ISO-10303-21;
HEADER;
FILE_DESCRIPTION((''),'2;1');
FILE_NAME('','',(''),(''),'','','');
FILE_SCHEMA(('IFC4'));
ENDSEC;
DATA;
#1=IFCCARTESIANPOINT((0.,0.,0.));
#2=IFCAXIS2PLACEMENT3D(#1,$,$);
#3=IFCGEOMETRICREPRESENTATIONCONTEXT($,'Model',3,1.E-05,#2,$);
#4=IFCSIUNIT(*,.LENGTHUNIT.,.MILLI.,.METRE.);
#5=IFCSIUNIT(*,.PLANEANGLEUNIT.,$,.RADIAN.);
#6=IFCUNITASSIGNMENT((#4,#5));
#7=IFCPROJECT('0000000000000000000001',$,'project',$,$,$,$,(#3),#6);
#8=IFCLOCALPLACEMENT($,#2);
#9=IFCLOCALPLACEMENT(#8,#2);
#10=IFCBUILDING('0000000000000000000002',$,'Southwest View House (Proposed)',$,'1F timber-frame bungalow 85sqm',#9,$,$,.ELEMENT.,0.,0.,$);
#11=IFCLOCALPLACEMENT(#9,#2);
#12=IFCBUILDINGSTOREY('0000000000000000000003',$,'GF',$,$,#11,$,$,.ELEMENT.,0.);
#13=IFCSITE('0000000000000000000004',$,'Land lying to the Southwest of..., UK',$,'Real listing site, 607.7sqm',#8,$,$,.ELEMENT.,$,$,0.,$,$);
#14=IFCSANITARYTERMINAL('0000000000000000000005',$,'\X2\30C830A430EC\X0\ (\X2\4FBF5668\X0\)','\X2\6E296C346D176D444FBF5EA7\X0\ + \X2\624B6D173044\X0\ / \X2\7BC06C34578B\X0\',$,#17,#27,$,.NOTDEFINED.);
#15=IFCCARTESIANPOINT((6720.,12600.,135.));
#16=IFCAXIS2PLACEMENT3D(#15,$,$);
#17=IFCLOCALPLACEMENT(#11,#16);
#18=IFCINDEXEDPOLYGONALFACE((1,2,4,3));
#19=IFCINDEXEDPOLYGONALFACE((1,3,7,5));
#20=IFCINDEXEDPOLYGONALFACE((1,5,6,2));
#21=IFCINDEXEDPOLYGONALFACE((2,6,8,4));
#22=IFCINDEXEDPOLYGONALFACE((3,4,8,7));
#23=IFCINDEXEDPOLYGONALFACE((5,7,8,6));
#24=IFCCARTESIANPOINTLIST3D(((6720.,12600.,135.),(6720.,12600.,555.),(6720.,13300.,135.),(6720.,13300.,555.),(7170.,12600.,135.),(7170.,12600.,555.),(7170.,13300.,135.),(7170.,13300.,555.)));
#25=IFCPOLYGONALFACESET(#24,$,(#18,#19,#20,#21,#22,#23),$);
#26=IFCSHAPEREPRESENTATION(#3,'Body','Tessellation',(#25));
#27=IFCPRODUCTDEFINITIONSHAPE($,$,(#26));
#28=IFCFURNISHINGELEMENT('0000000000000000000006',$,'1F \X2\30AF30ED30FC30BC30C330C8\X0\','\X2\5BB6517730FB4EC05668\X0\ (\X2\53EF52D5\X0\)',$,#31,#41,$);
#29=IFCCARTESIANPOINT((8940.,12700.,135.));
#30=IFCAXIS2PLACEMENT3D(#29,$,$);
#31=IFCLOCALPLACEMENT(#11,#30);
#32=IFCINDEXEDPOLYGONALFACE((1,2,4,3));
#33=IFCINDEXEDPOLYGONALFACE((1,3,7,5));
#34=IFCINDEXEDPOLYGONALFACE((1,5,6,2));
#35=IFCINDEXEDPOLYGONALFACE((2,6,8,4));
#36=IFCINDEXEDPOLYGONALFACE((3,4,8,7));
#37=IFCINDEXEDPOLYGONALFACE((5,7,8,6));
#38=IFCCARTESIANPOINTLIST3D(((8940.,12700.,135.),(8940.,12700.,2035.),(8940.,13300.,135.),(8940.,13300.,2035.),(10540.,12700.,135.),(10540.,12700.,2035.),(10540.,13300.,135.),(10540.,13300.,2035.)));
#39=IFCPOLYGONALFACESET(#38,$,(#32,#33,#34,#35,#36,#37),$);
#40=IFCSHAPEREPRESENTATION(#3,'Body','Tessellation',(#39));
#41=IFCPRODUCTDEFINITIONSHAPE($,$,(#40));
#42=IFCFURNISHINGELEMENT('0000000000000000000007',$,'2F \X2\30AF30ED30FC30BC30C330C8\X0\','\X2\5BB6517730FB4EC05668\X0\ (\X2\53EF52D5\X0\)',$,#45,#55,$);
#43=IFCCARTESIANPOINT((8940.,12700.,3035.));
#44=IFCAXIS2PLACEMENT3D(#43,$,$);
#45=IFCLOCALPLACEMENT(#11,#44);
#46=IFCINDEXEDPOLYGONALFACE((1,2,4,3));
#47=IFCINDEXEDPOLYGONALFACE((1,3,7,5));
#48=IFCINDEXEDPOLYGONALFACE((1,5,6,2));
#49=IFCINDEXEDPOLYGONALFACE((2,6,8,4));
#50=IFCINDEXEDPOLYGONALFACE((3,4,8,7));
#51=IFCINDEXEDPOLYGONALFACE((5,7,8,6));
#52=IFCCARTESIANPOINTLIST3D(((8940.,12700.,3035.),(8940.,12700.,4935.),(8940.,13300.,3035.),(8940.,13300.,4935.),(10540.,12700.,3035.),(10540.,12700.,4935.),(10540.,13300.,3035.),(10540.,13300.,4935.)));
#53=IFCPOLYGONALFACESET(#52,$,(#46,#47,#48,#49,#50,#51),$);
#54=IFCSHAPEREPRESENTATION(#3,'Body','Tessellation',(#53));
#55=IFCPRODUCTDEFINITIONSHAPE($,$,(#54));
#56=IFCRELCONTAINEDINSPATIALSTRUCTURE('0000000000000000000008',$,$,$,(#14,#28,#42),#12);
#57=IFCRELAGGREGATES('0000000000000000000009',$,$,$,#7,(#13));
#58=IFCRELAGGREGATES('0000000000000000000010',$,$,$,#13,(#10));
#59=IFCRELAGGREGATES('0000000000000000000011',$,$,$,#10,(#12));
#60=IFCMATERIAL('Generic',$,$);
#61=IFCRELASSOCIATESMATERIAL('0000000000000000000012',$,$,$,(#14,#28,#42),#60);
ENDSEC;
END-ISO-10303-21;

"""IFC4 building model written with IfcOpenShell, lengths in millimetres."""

from ifc_helpers import new_model, si_unit, frame, frame_2d, origin, place, context, project, spatial, rectangle, extrude, material, element, save


model = new_model("IFC4")

# Units and contexts
model_context = context("Model", 3, precision=1e-05, world=origin())
ifc_project = project(units=[si_unit("LENGTHUNIT", "METRE", prefix="MILLI"), si_unit("PLANEANGLEUNIT", "RADIAN")], contexts=[model_context])

# Site, building, storey
site_placement = place(None, origin())
site = spatial("IfcSite", under=ifc_project, at=site_placement, Name="Land lying to the Southwest of..., UK", ObjectType="Real listing site, 607.7sqm", CompositionType="ELEMENT", RefElevation=0.0)
building_placement = place(site_placement, origin())
building = spatial("IfcBuilding", under=site, at=building_placement, Name="Southwest View House (Proposed)", ObjectType="1F timber-frame bungalow 85sqm", CompositionType="ELEMENT", ElevationOfRefHeight=0.0, ElevationOfTerrain=0.0)
storey_placement = place(building_placement, origin())
storey = spatial("IfcBuildingStorey", under=building, at=storey_placement, Name="GF", CompositionType="ELEMENT", Elevation=0.0)

# Sanitary terminal
ifc_material_1 = material(Name="Generic")
sanitary_terminal_1_placement = place(storey_placement, frame((6720.0, 12600.0, 135.0)))
element("IfcSanitaryTerminal", 1, at=sanitary_terminal_1_placement, inside=storey, material=ifc_material_1, Name="トイレ (便器)", Description="温水洗浄便座 + 手洗い / 節水型", PredefinedType="NOTDEFINED", context=model_context, shape_type="SweptSolid", body=[
    extrude(rectangle(XDim=450.0, YDim=700.0, at=frame_2d((225.0, 350.0))), frame((6720.0, 12600.0, 135.0)), (0.0, 0.0, 1.0), 420.0),
])

# Furnishing elements
furnishing_1_placement = place(storey_placement, frame((8940.0, 12700.0, 135.0)))
element("IfcFurnishingElement", 2, at=furnishing_1_placement, inside=storey, material=ifc_material_1, Name="1F クローゼット", Description="家具・什器 (可動)", context=model_context, shape_type="SweptSolid", body=[
    extrude(rectangle(XDim=1600.0, YDim=600.0, at=frame_2d((800.0, 300.0))), frame((8940.0, 12700.0, 135.0)), (0.0, 0.0, 1.0), 1900.0),
])
furnishing_2_placement = place(storey_placement, frame((8940.0, 12700.0, 3035.0)))
element("IfcFurnishingElement", 3, at=furnishing_2_placement, inside=storey, material=ifc_material_1, Name="2F クローゼット", Description="家具・什器 (可動)", context=model_context, shape_type="SweptSolid", body=[
    extrude(rectangle(XDim=1600.0, YDim=600.0, at=frame_2d((800.0, 300.0))), frame((8940.0, 12700.0, 3035.0)), (0.0, 0.0, 1.0), 1900.0),
])

save(model, "model.ifc")
